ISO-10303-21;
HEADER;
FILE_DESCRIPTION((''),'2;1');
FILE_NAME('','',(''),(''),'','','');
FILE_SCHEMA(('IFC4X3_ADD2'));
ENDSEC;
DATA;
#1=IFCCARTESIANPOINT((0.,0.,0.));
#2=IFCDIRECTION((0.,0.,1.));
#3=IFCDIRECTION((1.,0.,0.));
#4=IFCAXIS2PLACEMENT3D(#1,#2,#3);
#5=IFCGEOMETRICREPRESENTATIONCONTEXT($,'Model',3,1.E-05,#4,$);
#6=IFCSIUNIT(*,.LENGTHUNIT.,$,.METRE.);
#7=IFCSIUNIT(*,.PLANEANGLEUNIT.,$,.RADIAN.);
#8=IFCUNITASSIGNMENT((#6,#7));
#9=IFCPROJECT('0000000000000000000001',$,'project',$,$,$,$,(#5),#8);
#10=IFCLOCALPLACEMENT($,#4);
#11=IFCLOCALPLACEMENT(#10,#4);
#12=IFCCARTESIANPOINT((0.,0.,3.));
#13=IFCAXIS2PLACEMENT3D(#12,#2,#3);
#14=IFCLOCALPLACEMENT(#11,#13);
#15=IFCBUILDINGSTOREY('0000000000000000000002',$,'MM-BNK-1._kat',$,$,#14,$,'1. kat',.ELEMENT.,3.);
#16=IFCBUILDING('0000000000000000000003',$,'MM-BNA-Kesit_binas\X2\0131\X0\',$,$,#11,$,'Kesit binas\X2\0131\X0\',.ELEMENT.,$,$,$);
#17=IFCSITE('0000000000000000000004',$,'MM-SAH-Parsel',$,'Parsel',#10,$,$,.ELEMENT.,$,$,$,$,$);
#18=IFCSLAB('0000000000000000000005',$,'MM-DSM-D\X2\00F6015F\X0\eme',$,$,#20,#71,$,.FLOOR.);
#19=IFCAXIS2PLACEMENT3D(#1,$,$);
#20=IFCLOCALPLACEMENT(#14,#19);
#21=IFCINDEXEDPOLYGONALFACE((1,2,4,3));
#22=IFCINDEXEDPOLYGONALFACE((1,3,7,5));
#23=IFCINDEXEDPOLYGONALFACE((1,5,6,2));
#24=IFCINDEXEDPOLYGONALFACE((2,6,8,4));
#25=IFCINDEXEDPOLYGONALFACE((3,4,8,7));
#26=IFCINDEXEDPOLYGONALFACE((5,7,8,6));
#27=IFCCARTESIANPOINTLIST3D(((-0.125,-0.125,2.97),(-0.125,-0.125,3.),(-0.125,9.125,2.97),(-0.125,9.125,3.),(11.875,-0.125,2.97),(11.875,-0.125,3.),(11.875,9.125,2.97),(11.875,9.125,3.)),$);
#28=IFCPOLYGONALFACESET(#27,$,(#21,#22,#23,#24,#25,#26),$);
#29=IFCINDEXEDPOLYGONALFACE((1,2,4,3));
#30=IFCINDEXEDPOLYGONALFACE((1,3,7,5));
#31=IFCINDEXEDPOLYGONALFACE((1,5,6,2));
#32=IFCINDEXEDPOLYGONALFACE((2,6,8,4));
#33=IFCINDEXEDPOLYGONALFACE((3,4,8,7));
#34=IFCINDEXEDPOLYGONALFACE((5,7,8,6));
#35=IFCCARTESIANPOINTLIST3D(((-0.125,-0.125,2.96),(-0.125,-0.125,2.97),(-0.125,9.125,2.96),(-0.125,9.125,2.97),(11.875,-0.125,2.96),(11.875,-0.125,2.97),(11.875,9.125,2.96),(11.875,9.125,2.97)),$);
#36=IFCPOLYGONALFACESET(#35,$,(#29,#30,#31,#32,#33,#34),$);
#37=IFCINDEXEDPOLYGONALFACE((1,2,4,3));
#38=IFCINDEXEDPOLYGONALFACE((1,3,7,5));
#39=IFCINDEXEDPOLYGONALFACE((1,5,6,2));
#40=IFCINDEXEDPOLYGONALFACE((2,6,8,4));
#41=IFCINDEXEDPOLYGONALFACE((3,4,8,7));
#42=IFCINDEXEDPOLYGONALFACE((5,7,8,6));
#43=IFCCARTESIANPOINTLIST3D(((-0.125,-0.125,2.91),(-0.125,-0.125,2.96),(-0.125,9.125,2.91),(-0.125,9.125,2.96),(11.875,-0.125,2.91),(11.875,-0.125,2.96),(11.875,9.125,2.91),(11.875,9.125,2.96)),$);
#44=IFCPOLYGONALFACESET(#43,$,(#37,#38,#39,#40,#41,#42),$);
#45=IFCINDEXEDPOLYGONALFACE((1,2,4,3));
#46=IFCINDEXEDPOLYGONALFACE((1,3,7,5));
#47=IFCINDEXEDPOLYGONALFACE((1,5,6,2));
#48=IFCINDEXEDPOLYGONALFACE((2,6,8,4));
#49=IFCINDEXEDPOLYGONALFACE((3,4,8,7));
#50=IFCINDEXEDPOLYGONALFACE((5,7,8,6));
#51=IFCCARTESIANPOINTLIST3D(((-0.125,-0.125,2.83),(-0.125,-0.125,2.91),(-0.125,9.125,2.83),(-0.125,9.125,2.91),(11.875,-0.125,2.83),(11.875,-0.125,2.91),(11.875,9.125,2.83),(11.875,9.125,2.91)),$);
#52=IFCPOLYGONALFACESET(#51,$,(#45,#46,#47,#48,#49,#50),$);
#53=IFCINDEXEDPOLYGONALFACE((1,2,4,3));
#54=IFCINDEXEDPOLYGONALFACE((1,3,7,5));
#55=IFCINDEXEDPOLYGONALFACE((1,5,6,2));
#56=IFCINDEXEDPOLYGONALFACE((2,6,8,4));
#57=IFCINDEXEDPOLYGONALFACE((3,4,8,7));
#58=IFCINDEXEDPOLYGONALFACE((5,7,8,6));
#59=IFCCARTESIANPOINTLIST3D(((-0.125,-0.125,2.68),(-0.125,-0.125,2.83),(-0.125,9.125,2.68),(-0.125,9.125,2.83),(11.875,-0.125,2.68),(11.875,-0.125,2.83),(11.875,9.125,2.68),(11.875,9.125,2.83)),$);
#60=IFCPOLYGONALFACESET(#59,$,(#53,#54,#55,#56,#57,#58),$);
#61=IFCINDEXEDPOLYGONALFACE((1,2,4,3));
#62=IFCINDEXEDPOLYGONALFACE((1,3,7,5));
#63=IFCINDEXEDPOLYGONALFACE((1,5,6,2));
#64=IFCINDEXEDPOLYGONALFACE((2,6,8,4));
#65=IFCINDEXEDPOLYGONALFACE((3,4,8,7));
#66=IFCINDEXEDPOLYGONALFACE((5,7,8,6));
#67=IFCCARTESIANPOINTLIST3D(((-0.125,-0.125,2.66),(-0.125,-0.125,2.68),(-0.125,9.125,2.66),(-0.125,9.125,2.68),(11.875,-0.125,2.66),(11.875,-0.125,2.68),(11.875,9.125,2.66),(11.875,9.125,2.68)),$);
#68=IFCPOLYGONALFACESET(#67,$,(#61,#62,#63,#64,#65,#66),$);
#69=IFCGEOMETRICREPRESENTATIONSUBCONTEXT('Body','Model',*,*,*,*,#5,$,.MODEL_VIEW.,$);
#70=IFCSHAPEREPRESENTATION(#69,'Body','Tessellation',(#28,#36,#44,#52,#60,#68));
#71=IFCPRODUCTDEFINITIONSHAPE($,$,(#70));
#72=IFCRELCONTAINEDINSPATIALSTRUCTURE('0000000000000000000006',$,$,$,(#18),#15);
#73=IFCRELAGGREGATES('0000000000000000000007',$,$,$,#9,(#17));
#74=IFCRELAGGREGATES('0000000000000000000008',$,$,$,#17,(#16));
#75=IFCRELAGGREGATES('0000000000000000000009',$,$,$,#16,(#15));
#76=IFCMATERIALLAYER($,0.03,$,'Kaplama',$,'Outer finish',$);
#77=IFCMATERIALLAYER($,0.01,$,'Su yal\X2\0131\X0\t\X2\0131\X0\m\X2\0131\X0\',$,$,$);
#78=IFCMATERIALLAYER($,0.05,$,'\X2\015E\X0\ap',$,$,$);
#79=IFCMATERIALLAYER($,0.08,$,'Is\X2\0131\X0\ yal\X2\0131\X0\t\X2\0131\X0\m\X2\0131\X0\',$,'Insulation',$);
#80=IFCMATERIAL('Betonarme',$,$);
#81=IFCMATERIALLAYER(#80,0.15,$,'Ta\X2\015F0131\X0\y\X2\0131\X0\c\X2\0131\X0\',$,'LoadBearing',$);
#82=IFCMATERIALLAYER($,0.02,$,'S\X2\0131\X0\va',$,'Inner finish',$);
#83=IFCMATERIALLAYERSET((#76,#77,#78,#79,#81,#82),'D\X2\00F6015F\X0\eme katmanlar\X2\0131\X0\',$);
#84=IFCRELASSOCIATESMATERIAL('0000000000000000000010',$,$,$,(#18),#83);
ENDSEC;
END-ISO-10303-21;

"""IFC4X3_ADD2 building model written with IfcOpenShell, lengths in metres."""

from ifc_helpers import new_model, si_unit, frame, origin_with_axes, place, context, subcontext, project, spatial, polyline, outline, extrude, material, layer, layer_set, layer_usage, element, save


model = new_model("IFC4X3_ADD2")

# Units and contexts
model_context = context("Model", 3, precision=1e-05, world=origin_with_axes())
body_context = subcontext(model_context, "Body", "Model", "MODEL_VIEW")
ifc_project = project(units=[si_unit("LENGTHUNIT", "METRE"), si_unit("PLANEANGLEUNIT", "RADIAN")], contexts=[model_context])

# Site, building, storey
site_placement = place(None, origin_with_axes())
site = spatial("IfcSite", under=ifc_project, at=site_placement, Name="MM-SAH-Parsel", ObjectType="Parsel", CompositionType="ELEMENT")
building_placement = place(site_placement, origin_with_axes())
building = spatial("IfcBuilding", under=site, at=building_placement, Name="MM-BNA-Kesit_binası", LongName="Kesit binası", CompositionType="ELEMENT")
storey_placement = place(building_placement, frame((0.0, 0.0, 3.0), z_axis=(0.0, 0.0, 1.0), x_axis=(1.0, 0.0, 0.0)))
storey = spatial("IfcBuildingStorey", under=building, at=storey_placement, Name="MM-BNK-1._kat", LongName="1. kat", CompositionType="ELEMENT", Elevation=3.0)

# Shared definitions
ifc_material_1 = material(Name="Betonarme")

# Slab
ifc_layer_1 = layer(None, 0.03, Name="Kaplama", Category="Outer finish")
ifc_layer_2 = layer(None, 0.01, Name="Su yalıtımı")
ifc_layer_3 = layer(None, 0.05, Name="Şap")
ifc_layer_4 = layer(None, 0.08, Name="Isı yalıtımı", Category="Insulation")
ifc_layer_5 = layer(ifc_material_1, 0.15, Name="Taşıyıcı", Category="LoadBearing")
ifc_layer_6 = layer(None, 0.02, Name="Sıva", Category="Inner finish")
ifc_layer_set_1 = layer_set([ifc_layer_1, ifc_layer_2, ifc_layer_3, ifc_layer_4, ifc_layer_5, ifc_layer_6], Name="Döşeme katmanları")
ifc_layer_usage_1 = layer_usage(ifc_layer_set_1, "AXIS3", "NEGATIVE", 3.0)
slab_1_placement = place(storey_placement, origin_with_axes())
element("IfcSlab", 1, at=slab_1_placement, inside=storey, material=ifc_layer_usage_1, Name="MM-DSM-Döşeme", PredefinedType="FLOOR", context=body_context, shape_type="SweptSolid", body=[
    extrude(outline(polyline([(-0.125, -0.125), (11.875, -0.125), (11.875, 9.125), (-0.125, 9.125), (-0.125, -0.125)])), frame((0.0, 0.0, 2.97)), (0.0, 0.0, 1.0), 0.03),
    extrude(outline(polyline([(-0.125, -0.125), (11.875, -0.125), (11.875, 9.125), (-0.125, 9.125), (-0.125, -0.125)])), frame((0.0, 0.0, 2.96)), (0.0, 0.0, 1.0), 0.01),
    extrude(outline(polyline([(-0.125, -0.125), (11.875, -0.125), (11.875, 9.125), (-0.125, 9.125), (-0.125, -0.125)])), frame((0.0, 0.0, 2.91)), (0.0, 0.0, 1.0), 0.05),
    extrude(outline(polyline([(-0.125, -0.125), (11.875, -0.125), (11.875, 9.125), (-0.125, 9.125), (-0.125, -0.125)])), frame((0.0, 0.0, 2.83)), (0.0, 0.0, 1.0), 0.08),
    extrude(outline(polyline([(-0.125, -0.125), (11.875, -0.125), (11.875, 9.125), (-0.125, 9.125), (-0.125, -0.125)])), frame((0.0, 0.0, 2.68)), (0.0, 0.0, 1.0), 0.15),
    extrude(outline(polyline([(-0.125, -0.125), (11.875, -0.125), (11.875, 9.125), (-0.125, 9.125), (-0.125, -0.125)])), frame((0.0, 0.0, 2.66)), (0.0, 0.0, 1.0), 0.02),
])

save(model, "model.ifc")
